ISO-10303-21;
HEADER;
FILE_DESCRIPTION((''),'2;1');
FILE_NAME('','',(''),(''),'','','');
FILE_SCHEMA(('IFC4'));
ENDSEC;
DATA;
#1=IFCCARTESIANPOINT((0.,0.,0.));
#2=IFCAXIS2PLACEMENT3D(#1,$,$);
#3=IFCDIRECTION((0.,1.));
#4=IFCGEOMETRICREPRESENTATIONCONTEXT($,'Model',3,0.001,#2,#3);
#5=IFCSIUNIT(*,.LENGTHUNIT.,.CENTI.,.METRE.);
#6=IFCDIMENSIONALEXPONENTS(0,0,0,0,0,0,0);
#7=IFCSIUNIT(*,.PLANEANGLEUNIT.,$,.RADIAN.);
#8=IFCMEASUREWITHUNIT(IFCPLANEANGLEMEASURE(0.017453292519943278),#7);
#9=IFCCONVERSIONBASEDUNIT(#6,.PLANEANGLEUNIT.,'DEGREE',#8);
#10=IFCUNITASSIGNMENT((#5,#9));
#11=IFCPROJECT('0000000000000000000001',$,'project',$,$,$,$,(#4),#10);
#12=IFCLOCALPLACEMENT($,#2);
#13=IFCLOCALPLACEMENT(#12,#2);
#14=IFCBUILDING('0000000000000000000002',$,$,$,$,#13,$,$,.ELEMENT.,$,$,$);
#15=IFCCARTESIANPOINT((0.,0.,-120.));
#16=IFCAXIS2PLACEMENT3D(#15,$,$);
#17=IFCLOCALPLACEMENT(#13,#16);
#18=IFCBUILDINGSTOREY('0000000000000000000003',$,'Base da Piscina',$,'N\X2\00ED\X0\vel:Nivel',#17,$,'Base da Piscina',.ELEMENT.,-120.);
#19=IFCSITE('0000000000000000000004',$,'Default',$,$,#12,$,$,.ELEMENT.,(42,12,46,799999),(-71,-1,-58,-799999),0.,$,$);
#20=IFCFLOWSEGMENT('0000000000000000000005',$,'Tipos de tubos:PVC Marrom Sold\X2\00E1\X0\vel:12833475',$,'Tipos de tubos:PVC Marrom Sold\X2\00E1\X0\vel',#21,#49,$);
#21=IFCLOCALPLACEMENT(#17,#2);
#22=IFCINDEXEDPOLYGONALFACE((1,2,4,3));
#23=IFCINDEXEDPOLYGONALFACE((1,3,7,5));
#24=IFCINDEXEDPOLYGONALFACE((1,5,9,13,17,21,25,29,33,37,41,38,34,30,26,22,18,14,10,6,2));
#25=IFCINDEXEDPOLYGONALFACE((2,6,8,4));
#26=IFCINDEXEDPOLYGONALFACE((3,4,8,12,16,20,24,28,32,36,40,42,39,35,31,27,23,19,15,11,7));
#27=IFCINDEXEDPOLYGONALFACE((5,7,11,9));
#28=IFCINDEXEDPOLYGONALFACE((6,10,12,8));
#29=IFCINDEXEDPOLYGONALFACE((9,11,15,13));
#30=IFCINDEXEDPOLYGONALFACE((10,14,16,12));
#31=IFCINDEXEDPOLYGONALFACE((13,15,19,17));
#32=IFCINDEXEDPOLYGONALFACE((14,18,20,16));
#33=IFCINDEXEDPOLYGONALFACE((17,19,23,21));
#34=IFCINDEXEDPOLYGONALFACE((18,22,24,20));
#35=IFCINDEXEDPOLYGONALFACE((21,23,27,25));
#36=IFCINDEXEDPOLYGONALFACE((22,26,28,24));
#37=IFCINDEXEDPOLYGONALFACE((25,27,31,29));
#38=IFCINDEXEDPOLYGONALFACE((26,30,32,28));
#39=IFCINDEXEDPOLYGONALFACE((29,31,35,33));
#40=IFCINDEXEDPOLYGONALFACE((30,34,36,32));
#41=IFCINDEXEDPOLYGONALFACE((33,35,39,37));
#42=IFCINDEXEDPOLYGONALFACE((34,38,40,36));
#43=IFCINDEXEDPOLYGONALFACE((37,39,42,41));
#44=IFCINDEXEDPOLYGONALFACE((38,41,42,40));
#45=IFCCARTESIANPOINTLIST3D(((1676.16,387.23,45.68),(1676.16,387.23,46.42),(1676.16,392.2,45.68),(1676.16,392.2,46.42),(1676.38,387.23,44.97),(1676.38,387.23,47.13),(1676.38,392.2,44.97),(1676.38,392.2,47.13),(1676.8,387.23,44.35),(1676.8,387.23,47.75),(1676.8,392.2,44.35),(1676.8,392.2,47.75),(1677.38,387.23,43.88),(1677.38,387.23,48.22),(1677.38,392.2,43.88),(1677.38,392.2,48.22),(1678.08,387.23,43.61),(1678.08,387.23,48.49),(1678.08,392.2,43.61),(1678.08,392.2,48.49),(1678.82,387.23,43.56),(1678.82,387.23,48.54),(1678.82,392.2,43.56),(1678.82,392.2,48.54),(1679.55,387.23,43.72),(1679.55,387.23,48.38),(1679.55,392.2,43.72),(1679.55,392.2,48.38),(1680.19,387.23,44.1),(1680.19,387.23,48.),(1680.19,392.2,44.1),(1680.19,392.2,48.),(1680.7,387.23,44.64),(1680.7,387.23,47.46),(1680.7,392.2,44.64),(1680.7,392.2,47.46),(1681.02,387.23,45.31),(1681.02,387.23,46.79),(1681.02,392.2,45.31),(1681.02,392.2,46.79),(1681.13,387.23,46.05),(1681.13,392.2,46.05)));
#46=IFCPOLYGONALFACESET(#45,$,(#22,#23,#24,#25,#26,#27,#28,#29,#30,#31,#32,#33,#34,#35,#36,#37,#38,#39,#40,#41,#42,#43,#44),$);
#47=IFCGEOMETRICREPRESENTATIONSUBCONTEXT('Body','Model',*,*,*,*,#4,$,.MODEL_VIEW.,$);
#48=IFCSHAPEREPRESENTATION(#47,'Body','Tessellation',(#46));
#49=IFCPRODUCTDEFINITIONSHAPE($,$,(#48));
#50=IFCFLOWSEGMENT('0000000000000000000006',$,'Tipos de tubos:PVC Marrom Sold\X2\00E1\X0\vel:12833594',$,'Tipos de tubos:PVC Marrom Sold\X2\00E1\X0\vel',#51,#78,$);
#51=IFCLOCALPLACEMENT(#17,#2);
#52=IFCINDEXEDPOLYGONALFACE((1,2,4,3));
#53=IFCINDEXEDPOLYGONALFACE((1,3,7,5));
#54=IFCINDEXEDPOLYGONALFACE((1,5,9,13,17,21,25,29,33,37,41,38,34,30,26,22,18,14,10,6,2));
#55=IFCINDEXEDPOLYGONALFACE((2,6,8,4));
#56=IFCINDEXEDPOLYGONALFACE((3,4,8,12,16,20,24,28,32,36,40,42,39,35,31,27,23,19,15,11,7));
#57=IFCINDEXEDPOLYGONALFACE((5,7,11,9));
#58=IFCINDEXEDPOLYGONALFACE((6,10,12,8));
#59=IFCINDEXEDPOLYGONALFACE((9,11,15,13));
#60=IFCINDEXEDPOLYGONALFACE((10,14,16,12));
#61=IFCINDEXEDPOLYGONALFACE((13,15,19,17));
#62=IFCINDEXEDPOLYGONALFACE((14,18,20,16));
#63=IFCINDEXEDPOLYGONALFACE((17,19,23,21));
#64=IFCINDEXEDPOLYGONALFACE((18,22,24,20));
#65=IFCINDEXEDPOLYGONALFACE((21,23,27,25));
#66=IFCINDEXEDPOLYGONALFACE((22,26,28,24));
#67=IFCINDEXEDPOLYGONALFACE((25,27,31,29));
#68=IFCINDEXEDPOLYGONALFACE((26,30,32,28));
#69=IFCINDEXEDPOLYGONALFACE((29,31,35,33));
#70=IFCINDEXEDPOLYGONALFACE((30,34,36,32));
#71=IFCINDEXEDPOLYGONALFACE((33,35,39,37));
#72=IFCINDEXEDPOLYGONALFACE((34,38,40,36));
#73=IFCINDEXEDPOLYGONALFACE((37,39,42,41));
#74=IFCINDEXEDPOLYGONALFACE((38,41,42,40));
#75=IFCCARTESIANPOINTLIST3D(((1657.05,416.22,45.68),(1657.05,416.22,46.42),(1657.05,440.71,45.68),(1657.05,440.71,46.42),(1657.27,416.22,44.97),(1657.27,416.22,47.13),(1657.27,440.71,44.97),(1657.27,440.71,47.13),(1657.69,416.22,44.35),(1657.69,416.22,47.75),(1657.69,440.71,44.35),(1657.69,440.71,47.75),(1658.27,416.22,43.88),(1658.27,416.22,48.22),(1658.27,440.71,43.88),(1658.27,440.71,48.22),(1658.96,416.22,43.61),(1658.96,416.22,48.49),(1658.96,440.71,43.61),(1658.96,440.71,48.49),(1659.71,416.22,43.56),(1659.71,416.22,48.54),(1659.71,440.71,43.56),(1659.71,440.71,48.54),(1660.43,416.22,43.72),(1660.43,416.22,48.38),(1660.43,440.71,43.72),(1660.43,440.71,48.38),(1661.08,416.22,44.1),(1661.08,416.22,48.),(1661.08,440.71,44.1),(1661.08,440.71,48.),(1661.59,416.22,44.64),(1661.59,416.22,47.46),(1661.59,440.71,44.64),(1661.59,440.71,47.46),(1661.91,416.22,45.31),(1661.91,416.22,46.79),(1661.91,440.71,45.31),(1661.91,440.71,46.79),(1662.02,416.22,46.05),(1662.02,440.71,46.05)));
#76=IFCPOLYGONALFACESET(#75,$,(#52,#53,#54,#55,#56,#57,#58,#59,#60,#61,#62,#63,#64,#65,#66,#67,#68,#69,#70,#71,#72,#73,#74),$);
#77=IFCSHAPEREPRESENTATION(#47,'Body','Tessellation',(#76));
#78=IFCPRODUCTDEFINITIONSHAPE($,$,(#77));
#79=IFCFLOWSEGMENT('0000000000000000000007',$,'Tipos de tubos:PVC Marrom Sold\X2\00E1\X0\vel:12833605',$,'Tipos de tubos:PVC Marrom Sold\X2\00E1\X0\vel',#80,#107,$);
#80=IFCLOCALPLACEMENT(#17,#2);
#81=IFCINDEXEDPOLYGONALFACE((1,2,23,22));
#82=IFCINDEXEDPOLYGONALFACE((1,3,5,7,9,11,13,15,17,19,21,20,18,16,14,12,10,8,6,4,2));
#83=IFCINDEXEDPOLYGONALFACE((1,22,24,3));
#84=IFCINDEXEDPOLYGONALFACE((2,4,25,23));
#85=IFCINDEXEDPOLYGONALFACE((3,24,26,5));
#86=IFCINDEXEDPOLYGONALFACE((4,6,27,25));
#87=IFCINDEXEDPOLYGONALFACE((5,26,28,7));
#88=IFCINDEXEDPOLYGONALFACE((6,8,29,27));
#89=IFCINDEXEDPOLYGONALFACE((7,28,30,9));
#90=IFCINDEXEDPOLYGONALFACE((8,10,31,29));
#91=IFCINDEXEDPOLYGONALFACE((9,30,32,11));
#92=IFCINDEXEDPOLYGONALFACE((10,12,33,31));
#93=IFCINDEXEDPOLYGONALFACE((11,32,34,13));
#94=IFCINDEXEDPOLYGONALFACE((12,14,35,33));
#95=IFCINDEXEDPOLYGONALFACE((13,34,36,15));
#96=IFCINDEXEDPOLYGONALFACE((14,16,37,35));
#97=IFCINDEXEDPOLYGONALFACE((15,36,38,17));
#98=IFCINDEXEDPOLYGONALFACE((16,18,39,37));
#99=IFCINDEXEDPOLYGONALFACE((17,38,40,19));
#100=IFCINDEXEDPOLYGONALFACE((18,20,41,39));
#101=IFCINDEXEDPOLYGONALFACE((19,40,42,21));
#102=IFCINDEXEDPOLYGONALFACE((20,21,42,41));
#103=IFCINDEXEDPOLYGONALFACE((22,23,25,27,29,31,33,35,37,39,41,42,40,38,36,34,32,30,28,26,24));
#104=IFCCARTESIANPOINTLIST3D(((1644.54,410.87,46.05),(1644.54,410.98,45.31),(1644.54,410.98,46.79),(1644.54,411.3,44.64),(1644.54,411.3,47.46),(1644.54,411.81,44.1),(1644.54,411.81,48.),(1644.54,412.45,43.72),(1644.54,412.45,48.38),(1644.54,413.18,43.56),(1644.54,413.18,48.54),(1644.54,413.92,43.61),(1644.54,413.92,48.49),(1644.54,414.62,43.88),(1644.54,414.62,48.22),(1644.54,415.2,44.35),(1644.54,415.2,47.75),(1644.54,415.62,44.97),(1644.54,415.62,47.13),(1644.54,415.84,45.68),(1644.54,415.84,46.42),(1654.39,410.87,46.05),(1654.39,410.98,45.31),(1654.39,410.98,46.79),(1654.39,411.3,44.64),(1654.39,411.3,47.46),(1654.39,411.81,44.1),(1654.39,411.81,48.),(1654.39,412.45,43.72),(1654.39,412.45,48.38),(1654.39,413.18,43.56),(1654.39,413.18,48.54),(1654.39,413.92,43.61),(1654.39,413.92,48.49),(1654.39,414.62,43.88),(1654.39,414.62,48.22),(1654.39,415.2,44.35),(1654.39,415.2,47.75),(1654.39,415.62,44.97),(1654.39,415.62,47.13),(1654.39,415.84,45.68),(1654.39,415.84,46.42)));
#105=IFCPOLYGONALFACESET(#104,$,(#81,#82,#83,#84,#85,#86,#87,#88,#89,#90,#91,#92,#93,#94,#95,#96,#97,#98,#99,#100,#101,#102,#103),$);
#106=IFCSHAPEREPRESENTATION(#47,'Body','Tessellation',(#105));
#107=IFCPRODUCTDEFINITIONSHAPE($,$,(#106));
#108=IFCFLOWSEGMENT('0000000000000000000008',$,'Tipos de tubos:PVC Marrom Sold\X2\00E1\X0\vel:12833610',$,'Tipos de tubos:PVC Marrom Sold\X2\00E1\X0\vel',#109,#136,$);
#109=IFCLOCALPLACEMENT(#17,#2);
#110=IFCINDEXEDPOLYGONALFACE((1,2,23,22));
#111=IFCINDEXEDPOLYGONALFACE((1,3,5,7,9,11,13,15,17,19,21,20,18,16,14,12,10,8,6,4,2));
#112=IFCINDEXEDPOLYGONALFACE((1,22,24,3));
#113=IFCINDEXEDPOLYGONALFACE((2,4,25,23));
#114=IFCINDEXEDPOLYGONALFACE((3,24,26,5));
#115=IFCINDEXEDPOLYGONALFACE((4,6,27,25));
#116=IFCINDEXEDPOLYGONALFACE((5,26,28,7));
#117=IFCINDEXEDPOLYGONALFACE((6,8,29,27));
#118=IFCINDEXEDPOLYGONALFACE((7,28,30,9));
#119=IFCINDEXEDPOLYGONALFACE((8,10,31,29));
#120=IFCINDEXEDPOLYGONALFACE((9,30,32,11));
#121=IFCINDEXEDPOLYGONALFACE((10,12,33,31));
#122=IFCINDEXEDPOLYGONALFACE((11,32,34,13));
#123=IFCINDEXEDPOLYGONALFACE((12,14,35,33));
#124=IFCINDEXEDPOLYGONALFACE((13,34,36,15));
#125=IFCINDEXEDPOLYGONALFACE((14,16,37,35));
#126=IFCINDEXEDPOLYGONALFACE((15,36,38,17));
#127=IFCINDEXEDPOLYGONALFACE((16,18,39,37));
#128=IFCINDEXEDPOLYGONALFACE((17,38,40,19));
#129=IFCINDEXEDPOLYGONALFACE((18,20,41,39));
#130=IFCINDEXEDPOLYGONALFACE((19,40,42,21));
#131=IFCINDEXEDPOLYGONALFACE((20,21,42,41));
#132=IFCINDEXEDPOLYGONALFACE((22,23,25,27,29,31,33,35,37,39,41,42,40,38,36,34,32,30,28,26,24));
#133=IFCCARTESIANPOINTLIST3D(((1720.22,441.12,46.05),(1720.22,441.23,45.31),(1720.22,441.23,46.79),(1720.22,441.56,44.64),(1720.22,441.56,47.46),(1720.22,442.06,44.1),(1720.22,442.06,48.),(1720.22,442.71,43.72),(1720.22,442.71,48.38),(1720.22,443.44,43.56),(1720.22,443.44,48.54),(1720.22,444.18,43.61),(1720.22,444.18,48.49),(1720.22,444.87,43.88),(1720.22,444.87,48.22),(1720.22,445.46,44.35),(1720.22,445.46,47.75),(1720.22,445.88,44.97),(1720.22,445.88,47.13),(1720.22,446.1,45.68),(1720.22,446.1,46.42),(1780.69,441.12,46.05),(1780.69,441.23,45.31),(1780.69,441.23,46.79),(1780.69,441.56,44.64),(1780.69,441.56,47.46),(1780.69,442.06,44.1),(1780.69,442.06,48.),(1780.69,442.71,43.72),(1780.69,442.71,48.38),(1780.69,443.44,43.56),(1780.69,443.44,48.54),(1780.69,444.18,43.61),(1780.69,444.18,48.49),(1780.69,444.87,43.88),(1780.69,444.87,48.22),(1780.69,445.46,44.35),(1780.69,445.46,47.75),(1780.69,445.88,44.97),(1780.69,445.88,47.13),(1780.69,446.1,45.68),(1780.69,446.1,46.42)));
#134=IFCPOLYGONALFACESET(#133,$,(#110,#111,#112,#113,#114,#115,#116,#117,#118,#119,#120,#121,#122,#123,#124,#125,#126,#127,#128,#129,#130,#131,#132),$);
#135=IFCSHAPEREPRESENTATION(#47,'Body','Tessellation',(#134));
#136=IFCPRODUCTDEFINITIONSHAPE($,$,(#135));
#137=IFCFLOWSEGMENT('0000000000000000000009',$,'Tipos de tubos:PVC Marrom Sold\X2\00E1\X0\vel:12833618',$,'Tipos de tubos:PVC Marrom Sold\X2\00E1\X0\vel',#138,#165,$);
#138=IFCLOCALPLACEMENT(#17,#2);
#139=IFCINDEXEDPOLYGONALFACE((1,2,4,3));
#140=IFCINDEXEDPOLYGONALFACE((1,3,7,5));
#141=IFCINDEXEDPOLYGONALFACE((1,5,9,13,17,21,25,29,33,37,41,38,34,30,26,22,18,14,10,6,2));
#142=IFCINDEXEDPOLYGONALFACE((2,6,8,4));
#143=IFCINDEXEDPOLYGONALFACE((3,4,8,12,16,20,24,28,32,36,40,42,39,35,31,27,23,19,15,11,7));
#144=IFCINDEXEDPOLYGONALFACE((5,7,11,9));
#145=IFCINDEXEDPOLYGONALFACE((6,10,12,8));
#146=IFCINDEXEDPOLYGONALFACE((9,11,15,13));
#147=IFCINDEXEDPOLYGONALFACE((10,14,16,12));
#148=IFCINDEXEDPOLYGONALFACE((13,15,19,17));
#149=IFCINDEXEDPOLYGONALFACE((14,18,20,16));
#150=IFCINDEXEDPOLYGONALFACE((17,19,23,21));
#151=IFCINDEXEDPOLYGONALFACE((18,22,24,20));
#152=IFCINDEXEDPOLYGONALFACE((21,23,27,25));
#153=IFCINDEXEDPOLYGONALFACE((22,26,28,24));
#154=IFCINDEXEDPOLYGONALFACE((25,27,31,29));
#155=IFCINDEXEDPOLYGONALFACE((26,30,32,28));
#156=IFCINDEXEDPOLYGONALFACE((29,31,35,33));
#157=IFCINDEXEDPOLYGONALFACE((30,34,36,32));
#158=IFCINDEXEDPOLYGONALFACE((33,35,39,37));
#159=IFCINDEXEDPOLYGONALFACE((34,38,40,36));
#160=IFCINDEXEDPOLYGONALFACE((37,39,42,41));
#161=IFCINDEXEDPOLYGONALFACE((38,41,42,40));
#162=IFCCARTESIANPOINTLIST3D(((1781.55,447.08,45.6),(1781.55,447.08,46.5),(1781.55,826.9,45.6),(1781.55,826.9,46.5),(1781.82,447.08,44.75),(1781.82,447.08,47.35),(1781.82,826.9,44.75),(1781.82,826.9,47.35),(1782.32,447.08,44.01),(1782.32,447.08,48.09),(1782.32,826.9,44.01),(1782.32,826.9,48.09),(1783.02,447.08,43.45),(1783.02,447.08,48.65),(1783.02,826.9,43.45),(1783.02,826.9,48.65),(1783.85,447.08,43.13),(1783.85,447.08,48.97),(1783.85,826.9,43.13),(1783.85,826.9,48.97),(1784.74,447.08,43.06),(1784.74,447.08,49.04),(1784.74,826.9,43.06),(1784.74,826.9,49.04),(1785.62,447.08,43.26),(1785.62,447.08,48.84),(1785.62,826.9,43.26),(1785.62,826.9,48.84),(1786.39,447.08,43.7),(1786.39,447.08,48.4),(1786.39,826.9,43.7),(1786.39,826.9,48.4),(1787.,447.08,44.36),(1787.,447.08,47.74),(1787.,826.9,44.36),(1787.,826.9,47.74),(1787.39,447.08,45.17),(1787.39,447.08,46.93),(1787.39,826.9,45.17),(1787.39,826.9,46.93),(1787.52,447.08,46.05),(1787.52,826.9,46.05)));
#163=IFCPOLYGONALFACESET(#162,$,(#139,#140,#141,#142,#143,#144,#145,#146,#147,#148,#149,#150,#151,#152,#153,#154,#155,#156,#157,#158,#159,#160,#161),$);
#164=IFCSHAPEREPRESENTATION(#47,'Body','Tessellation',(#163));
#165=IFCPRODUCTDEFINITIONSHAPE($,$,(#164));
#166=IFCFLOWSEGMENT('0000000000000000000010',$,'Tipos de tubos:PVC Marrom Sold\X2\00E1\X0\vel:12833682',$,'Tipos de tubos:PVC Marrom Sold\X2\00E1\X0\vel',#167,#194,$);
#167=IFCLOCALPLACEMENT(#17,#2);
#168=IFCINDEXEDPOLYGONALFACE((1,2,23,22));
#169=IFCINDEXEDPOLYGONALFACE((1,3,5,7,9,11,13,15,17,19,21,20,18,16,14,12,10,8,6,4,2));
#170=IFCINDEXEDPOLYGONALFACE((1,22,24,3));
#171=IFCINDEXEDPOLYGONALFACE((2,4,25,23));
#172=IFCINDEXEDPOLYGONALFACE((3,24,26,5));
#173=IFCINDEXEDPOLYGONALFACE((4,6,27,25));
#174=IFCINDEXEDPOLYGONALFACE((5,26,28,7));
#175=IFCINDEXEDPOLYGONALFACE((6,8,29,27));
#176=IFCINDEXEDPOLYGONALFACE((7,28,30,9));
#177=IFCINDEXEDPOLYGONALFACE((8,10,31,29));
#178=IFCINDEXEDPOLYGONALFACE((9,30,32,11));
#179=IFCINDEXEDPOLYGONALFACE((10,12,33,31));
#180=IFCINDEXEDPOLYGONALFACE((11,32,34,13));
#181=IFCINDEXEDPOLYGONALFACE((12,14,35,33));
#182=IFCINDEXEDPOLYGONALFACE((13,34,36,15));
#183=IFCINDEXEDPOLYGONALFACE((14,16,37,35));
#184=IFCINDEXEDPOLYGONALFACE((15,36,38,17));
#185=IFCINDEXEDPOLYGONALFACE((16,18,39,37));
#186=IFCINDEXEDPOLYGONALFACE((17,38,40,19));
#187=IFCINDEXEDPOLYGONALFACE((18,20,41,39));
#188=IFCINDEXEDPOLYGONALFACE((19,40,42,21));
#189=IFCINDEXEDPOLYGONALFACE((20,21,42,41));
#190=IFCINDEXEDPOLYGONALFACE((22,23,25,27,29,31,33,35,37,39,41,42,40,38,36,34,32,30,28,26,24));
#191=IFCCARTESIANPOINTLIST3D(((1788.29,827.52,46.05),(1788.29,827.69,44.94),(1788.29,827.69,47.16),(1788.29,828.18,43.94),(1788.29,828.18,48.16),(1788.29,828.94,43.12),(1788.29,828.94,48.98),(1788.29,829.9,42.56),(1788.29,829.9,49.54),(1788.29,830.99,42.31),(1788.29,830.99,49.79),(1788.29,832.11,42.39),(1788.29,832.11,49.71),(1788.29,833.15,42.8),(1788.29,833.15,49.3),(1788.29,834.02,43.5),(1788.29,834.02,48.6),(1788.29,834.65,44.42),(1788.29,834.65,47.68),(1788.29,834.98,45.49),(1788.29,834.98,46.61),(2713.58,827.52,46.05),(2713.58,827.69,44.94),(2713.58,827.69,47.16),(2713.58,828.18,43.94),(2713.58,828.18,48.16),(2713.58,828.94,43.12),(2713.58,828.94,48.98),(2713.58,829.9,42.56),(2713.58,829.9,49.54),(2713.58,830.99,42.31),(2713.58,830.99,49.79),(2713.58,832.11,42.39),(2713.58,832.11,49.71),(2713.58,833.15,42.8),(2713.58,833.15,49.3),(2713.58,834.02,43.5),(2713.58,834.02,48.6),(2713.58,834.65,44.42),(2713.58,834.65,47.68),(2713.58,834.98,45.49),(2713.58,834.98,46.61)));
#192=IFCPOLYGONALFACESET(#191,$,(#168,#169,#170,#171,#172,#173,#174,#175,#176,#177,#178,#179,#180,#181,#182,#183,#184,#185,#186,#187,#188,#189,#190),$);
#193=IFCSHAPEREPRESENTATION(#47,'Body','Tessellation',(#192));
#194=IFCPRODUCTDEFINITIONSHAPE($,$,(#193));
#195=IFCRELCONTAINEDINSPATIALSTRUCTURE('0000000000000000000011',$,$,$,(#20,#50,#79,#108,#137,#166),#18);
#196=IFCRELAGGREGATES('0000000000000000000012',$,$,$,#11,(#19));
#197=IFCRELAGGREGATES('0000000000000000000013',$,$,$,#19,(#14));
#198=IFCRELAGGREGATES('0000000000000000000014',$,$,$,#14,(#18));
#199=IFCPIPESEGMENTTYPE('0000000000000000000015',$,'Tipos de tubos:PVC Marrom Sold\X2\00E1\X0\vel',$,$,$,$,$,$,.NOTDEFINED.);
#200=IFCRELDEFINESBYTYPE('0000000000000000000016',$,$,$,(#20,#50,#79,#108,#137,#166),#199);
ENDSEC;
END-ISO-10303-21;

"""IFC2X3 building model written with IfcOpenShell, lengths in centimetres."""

from ifc_helpers import new_model, entity, si_unit, converted_unit, direction, frame, frame_2d, origin, origin_2d_with_axis, place, context, subcontext, project, spatial, circle, extrude, type_object, element, save


model = new_model("IFC2X3")

# Units and contexts
model_context = context("Model", 3, precision=0.001, world=origin(), true_north=direction((0.0, 1.0)))
body_context = subcontext(model_context, "Body", "Model", "MODEL_VIEW")
ifc_project = project(units=[si_unit("LENGTHUNIT", "METRE", prefix="CENTI"), converted_unit("PLANEANGLEUNIT", "DEGREE", entity("IfcPlaneAngleMeasure", 0.017453292519943278), si_unit("PLANEANGLEUNIT", "RADIAN"), dimensions=[0, 0, 0, 0, 0, 0, 0])], contexts=[model_context])

# Site, building, storey
site_placement = place(None, origin())
site = spatial("IfcSite", under=ifc_project, at=site_placement, Name="Default", CompositionType="ELEMENT", RefLatitude=(42, 12, 46, 799999), RefLongitude=(-71, -1, -58, -799999), RefElevation=0.0)
building_placement = place(site_placement, origin())
building = spatial("IfcBuilding", under=site, at=building_placement, CompositionType="ELEMENT")
storey_placement = place(building_placement, frame((0.0, 0.0, -120.0)))
storey = spatial("IfcBuildingStorey", under=building, at=storey_placement, Name="Base da Piscina", ObjectType="Nível:Nivel", LongName="Base da Piscina", CompositionType="ELEMENT", Elevation=-120.0)

# Flow segments
pipe_segment_type = type_object("IfcPipeSegmentType", Name="Tipos de tubos:PVC Marrom Soldável", PredefinedType="NOTDEFINED")
flow_segment_1_placement = place(storey_placement, origin())
element("IfcFlowSegment", 1, at=flow_segment_1_placement, inside=storey, type_object=pipe_segment_type, Name="Tipos de tubos:PVC Marrom Soldável:12833475", ObjectType="Tipos de tubos:PVC Marrom Soldável", context=body_context, shape_type="SweptSolid", body=[
    extrude(circle(Radius=2.5, at=origin_2d_with_axis()), frame((1678.63, 387.23, 46.05), z_axis=(0.0, 1.0, 0.0), x_axis=(1.0, 0.0, 0.0)), (0.0, 0.0, 1.0), 4.97),
])
flow_segment_2_placement = place(storey_placement, origin())
element("IfcFlowSegment", 2, at=flow_segment_2_placement, inside=storey, type_object=pipe_segment_type, Name="Tipos de tubos:PVC Marrom Soldável:12833594", ObjectType="Tipos de tubos:PVC Marrom Soldável", context=body_context, shape_type="SweptSolid", body=[
    extrude(circle(Radius=2.5, at=origin_2d_with_axis()), frame((1659.52, 416.22, 46.05), z_axis=(0.0, 1.0, 0.0), x_axis=(1.0, 0.0, 0.0)), (0.0, 0.0, 1.0), 24.49),
])
flow_segment_3_placement = place(storey_placement, origin())
element("IfcFlowSegment", 3, at=flow_segment_3_placement, inside=storey, type_object=pipe_segment_type, Name="Tipos de tubos:PVC Marrom Soldável:12833605", ObjectType="Tipos de tubos:PVC Marrom Soldável", context=body_context, shape_type="SweptSolid", body=[
    extrude(circle(Radius=2.5, at=origin_2d_with_axis()), frame((1644.54, 413.37, 46.05), z_axis=(1.0, 0.0, 0.0), x_axis=(0.0, -1.0, 0.0)), (0.0, 0.0, 1.0), 9.85),
])
flow_segment_4_placement = place(storey_placement, origin())
element("IfcFlowSegment", 4, at=flow_segment_4_placement, inside=storey, type_object=pipe_segment_type, Name="Tipos de tubos:PVC Marrom Soldável:12833610", ObjectType="Tipos de tubos:PVC Marrom Soldável", context=body_context, shape_type="SweptSolid", body=[
    extrude(circle(Radius=2.5, at=origin_2d_with_axis()), frame((1720.22, 443.62, 46.05), z_axis=(1.0, 0.0, 0.0), x_axis=(0.0, -1.0, 0.0)), (0.0, 0.0, 1.0), 60.46),
])
flow_segment_5_placement = place(storey_placement, origin())
element("IfcFlowSegment", 5, at=flow_segment_5_placement, inside=storey, type_object=pipe_segment_type, Name="Tipos de tubos:PVC Marrom Soldável:12833618", ObjectType="Tipos de tubos:PVC Marrom Soldável", context=body_context, shape_type="SweptSolid", body=[
    extrude(circle(Radius=3.0, at=origin_2d_with_axis()), frame((1784.52, 447.08, 46.05), z_axis=(0.0, 1.0, 0.0), x_axis=(1.0, 0.0, 0.0)), (0.0, 0.0, 1.0), 379.82),
])
flow_segment_6_placement = place(storey_placement, origin())
element("IfcFlowSegment", 6, at=flow_segment_6_placement, inside=storey, type_object=pipe_segment_type, Name="Tipos de tubos:PVC Marrom Soldável:12833682", ObjectType="Tipos de tubos:PVC Marrom Soldável", context=body_context, shape_type="SweptSolid", body=[
    extrude(circle(Radius=3.75, at=frame_2d((0.0, 0.0), x_axis=(1.0, 0.0))), frame((1788.29, 831.27, 46.05), z_axis=(1.0, 0.0, 0.0), x_axis=(0.0, -1.0, 0.0)), (0.0, 0.0, 1.0), 925.29),
])

save(model, "model.ifc")
